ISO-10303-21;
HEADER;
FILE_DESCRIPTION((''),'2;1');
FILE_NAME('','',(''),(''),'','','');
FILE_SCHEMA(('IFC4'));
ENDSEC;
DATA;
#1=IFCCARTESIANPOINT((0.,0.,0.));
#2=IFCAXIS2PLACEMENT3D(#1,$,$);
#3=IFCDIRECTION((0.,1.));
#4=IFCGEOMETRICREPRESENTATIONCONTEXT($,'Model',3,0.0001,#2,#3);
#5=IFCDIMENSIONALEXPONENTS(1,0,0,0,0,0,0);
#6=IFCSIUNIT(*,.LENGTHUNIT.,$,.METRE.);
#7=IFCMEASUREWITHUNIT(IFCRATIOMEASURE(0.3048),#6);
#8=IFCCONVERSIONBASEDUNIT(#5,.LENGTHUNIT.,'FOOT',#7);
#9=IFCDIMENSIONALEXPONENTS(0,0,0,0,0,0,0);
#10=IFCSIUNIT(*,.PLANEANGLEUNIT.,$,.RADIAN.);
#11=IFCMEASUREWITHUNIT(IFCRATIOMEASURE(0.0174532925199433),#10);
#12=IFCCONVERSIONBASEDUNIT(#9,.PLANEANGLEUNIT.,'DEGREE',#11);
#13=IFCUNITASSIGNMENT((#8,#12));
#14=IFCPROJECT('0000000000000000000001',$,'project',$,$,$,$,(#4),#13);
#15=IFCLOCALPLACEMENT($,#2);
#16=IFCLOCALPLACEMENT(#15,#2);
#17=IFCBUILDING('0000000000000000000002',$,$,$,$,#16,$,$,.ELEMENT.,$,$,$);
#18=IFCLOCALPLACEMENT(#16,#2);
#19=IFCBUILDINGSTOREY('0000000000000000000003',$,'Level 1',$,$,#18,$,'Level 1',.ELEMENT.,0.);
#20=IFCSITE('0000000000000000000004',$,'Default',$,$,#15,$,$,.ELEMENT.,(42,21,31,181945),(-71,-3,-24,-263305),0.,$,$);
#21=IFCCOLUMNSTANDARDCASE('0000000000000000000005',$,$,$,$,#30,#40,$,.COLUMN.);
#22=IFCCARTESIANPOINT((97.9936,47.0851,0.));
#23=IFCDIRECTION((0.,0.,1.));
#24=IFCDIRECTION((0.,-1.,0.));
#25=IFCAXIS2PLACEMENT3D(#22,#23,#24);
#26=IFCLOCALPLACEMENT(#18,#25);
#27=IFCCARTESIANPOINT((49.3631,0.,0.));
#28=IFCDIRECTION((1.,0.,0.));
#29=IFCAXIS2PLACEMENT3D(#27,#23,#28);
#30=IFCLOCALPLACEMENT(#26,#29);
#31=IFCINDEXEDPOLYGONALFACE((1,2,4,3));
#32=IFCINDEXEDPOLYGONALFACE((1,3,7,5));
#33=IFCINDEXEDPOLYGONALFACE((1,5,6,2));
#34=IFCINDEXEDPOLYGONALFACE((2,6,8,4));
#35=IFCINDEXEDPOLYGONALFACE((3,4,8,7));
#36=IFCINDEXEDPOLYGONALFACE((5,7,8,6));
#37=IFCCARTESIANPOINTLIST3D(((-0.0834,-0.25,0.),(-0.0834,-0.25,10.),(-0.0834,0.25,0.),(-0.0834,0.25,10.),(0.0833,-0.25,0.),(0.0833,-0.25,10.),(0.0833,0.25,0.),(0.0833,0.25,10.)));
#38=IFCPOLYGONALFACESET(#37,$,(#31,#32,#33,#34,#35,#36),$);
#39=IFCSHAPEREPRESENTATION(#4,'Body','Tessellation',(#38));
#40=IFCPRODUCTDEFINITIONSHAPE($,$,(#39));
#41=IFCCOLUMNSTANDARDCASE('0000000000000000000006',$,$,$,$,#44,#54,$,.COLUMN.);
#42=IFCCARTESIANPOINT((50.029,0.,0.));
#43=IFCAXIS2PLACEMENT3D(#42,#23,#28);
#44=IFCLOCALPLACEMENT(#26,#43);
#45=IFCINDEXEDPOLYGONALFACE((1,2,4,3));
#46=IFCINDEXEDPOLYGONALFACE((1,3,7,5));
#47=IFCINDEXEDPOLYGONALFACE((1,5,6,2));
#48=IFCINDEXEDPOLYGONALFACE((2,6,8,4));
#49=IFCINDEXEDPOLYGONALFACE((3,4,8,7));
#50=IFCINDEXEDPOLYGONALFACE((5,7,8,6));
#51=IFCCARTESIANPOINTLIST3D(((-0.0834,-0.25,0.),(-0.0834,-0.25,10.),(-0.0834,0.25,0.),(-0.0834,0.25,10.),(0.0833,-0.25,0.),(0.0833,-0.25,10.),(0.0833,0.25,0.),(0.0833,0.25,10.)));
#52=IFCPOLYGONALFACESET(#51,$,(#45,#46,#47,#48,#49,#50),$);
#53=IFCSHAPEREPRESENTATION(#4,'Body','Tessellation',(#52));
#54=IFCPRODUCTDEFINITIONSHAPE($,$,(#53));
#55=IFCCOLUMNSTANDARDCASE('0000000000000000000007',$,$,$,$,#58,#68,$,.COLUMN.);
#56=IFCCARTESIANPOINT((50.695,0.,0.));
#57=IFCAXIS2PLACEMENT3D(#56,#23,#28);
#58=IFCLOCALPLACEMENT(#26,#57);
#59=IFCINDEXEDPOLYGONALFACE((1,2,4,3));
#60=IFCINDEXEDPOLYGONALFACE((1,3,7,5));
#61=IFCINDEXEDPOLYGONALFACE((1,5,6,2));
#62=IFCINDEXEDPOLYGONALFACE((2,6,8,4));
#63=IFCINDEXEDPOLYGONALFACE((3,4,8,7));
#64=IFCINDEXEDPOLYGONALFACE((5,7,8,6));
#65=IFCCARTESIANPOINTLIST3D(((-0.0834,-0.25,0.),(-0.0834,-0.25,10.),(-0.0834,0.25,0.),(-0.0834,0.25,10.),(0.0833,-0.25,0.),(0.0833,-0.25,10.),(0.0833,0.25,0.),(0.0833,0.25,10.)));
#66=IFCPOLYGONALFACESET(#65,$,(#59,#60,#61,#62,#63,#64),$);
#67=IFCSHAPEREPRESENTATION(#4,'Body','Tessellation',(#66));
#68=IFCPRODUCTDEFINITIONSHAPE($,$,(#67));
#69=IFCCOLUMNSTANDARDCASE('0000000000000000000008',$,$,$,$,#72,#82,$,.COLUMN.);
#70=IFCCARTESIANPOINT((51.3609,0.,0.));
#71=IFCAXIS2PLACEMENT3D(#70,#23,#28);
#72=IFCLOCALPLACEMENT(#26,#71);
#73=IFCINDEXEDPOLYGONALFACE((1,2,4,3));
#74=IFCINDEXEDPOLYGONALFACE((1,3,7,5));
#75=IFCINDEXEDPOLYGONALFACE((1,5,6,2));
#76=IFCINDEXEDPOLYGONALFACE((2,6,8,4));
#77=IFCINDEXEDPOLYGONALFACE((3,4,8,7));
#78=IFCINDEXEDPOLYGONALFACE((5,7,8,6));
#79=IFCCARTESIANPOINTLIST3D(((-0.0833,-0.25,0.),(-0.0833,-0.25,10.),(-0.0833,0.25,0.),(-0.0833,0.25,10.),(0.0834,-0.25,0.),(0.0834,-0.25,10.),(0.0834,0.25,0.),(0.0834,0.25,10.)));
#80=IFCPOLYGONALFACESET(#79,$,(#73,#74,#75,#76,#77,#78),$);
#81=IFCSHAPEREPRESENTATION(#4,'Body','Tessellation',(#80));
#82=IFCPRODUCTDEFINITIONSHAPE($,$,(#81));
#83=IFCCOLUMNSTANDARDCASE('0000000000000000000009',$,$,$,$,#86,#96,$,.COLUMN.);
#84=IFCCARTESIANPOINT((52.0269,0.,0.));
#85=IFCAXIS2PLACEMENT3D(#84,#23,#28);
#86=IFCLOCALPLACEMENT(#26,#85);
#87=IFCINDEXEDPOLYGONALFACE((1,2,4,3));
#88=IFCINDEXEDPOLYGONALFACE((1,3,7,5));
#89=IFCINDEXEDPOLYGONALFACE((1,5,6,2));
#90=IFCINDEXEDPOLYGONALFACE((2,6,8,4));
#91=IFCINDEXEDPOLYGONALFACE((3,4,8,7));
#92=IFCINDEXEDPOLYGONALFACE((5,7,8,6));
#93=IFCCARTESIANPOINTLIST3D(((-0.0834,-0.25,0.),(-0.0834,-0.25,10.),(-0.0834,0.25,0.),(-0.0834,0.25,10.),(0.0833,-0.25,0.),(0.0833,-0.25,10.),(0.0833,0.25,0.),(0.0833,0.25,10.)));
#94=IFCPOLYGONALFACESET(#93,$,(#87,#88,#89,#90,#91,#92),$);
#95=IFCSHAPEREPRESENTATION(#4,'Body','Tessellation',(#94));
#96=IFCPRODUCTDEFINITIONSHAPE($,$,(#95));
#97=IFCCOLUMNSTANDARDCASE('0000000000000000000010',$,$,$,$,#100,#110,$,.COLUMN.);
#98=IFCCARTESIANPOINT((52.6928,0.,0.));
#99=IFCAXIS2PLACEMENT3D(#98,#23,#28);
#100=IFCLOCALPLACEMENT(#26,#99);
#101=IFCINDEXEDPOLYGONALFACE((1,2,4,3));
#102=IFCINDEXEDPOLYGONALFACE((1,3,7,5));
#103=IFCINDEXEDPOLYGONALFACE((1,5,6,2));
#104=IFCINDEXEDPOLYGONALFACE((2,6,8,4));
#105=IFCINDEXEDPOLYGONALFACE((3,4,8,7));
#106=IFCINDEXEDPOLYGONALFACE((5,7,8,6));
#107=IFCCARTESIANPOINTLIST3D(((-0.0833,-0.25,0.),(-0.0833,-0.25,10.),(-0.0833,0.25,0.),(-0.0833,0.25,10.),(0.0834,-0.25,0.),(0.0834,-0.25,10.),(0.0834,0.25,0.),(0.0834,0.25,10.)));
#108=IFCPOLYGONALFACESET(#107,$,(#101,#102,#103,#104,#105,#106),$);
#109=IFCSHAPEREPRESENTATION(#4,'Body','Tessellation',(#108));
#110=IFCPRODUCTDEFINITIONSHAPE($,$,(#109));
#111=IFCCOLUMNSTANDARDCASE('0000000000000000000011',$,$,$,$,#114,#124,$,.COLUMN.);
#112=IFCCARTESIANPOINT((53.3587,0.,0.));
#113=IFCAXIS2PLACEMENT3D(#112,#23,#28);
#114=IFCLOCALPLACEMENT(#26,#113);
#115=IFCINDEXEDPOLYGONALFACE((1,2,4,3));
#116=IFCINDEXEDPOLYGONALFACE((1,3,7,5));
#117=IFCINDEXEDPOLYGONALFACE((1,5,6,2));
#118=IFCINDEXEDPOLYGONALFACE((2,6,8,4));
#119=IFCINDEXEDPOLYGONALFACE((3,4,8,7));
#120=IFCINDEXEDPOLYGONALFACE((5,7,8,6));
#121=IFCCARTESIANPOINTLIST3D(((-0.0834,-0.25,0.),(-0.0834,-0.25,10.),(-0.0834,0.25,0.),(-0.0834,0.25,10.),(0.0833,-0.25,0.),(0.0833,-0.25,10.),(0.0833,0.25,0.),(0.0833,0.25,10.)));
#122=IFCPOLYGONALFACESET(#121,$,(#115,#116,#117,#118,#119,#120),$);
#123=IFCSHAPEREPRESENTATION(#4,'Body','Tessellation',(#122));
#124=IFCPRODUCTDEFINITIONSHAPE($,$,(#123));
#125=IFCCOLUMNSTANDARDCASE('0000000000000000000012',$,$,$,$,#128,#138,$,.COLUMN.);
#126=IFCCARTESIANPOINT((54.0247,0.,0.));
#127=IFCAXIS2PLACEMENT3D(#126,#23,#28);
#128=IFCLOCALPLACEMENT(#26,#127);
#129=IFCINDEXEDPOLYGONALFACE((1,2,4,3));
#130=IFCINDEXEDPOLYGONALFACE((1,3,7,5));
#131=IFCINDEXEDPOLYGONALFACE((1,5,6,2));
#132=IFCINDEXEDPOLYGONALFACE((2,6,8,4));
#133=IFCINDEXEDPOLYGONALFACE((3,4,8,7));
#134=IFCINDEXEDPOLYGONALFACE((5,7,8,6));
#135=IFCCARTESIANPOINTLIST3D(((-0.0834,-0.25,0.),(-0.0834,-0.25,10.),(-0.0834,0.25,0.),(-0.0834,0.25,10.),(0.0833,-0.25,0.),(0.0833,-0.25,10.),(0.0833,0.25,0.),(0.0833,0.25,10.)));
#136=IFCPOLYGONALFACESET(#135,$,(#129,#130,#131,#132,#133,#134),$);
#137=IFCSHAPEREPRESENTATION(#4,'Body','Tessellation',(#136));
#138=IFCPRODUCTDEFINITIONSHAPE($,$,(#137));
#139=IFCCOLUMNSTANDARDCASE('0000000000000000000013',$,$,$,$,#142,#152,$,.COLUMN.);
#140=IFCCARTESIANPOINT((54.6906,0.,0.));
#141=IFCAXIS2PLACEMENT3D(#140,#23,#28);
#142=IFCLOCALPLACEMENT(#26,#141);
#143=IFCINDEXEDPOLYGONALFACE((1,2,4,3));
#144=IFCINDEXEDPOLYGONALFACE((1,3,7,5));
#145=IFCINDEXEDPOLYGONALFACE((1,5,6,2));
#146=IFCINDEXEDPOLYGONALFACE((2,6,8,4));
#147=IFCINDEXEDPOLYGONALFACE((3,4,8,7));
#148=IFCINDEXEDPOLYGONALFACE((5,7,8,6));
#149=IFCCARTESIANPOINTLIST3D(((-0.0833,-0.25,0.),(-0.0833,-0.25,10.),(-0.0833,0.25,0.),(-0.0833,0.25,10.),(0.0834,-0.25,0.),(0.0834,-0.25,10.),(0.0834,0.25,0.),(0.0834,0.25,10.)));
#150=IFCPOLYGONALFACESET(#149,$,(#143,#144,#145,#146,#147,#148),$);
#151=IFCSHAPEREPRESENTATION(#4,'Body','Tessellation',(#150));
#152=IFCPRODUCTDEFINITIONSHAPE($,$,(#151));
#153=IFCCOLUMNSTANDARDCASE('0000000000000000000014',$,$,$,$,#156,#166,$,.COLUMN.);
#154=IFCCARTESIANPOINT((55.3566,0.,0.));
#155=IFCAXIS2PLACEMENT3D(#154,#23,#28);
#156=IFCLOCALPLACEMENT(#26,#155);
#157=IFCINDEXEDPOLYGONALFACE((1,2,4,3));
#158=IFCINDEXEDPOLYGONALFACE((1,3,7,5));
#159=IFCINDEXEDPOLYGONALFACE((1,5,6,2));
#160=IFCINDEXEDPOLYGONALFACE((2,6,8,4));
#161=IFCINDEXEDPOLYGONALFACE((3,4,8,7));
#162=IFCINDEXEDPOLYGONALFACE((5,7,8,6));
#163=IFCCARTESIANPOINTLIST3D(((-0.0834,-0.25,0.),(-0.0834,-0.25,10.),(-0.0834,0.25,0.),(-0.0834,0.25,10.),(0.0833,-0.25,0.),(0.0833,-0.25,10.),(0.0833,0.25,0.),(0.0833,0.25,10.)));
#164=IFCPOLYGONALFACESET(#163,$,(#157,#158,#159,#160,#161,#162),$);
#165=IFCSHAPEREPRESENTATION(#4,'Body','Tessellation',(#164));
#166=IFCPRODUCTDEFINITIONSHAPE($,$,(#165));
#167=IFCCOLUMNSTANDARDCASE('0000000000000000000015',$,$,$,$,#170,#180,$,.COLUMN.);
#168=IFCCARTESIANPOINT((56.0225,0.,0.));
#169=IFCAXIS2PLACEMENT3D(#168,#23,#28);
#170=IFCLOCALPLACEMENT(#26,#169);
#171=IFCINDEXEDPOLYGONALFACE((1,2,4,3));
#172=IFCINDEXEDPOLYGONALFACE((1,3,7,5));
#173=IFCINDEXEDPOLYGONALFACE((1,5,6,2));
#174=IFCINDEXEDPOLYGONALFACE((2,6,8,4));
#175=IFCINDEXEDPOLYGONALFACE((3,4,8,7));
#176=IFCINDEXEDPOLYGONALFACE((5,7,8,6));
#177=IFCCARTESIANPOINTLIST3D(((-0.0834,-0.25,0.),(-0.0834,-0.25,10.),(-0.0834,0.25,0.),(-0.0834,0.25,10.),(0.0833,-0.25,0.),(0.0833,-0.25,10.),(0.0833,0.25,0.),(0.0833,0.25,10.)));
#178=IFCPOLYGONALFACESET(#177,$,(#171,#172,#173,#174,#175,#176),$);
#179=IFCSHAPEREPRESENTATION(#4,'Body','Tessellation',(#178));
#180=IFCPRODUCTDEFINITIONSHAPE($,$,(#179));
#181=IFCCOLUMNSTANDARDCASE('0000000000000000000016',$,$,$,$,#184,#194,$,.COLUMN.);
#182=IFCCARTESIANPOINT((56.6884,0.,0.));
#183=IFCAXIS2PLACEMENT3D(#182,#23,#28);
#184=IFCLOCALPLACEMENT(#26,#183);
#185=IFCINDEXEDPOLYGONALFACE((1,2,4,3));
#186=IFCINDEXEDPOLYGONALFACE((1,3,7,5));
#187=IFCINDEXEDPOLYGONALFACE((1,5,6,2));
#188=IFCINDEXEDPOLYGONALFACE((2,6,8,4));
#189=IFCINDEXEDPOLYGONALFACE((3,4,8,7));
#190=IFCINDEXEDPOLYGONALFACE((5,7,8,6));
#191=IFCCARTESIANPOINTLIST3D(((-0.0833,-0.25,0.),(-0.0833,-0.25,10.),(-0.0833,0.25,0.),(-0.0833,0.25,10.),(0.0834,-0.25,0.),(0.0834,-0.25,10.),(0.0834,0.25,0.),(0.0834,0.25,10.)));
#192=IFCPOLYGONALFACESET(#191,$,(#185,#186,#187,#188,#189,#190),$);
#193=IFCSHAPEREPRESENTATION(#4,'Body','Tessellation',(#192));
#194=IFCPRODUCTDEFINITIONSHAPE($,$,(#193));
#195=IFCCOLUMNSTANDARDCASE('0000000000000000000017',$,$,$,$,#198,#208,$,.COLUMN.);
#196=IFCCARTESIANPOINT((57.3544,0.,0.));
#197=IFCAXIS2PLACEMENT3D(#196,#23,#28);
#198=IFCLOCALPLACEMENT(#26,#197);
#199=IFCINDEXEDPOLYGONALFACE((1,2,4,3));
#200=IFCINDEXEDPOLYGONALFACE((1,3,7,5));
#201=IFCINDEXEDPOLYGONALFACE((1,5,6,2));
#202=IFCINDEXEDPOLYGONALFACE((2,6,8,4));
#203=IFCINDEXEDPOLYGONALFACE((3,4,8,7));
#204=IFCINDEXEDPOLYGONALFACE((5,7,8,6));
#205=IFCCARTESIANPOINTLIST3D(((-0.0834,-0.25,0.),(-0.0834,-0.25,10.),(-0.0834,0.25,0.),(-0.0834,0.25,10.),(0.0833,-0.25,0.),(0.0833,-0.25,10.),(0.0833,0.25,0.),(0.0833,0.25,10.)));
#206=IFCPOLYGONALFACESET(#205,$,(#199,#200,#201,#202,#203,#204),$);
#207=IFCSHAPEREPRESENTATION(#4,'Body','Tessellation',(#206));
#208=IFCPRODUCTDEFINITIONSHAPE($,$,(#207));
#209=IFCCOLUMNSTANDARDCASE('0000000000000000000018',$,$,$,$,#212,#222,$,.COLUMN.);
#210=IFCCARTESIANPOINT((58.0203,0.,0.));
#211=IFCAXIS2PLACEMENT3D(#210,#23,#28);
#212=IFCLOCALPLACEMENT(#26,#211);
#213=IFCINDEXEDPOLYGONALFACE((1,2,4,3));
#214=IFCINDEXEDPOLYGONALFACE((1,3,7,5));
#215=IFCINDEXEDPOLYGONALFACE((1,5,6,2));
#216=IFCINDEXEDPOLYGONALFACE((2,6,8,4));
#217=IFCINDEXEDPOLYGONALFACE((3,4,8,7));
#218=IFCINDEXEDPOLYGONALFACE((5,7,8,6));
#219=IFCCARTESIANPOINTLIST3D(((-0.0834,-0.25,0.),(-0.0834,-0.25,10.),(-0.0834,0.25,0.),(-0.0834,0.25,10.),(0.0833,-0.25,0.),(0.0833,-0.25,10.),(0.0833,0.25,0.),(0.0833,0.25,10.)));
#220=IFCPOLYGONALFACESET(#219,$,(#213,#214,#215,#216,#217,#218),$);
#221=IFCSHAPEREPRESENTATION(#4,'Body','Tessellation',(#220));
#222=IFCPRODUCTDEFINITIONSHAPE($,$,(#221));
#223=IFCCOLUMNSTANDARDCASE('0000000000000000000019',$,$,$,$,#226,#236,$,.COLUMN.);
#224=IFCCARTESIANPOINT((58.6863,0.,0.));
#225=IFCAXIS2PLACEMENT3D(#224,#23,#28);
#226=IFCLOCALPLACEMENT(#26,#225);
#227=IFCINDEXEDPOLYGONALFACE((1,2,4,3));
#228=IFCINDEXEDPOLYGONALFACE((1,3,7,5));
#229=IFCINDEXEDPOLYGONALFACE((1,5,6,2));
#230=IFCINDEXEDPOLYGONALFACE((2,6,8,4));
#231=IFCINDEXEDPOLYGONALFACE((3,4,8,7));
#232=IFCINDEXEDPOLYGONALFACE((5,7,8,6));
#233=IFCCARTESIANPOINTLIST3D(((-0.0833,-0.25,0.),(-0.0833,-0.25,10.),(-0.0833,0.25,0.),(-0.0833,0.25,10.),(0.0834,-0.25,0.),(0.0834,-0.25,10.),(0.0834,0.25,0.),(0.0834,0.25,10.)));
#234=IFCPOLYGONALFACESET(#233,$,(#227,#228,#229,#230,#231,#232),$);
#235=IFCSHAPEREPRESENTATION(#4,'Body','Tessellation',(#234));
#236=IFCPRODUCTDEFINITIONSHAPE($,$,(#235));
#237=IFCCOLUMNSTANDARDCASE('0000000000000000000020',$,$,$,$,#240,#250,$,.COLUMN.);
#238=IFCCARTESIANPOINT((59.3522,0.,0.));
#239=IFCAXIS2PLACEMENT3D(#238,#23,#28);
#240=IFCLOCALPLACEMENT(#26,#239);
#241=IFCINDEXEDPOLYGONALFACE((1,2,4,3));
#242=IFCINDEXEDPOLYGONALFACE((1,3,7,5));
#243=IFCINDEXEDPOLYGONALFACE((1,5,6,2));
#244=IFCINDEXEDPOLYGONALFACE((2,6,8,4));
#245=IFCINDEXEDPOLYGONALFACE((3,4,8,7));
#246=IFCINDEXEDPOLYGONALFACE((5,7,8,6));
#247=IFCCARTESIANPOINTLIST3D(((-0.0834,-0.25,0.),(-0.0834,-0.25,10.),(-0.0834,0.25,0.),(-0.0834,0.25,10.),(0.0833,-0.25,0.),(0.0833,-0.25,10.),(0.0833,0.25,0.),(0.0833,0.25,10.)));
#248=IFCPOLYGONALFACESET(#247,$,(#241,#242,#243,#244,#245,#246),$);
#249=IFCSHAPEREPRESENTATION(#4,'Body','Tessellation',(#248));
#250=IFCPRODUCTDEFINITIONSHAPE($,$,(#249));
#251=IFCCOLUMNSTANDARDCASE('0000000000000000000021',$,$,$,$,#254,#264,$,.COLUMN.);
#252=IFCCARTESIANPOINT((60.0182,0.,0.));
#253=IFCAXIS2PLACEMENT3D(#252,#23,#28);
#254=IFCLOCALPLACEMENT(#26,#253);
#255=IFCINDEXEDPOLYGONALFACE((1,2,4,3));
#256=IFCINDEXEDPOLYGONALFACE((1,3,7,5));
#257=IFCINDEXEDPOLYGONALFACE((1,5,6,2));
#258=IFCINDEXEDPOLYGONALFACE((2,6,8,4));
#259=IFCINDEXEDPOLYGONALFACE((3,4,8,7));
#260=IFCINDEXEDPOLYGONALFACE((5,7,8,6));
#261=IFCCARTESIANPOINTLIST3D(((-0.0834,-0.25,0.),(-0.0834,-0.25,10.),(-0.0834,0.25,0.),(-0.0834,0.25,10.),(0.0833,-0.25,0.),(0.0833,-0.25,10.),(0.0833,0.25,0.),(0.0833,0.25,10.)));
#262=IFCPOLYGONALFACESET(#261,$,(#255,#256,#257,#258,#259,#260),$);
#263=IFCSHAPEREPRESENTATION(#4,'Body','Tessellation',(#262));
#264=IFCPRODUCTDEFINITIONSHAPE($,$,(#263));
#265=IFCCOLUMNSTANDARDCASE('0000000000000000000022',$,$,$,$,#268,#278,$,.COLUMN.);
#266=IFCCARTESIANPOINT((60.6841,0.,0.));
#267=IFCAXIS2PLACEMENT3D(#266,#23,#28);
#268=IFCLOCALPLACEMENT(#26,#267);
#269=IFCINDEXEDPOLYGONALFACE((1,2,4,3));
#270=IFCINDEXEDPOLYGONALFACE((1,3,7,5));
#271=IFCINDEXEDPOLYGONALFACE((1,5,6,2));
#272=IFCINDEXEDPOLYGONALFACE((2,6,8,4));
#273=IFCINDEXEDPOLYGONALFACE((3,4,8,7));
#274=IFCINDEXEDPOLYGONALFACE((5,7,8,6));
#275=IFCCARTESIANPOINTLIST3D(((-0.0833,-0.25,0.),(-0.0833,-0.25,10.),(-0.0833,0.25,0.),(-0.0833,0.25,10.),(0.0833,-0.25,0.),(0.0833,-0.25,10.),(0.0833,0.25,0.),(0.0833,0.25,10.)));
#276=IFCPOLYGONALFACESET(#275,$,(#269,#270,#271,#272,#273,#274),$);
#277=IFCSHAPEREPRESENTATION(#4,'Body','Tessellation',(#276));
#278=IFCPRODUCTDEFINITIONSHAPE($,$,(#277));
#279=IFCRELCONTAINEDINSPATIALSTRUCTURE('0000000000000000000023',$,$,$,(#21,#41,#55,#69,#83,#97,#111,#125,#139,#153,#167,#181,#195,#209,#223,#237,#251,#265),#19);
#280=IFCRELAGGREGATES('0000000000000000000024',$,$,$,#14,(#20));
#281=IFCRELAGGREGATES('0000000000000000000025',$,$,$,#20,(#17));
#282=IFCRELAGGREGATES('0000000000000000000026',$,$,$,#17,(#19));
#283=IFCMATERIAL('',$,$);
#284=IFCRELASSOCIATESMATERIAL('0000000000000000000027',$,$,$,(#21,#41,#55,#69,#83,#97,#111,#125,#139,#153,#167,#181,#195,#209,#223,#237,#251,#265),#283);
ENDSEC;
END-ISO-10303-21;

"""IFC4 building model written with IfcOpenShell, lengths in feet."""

from ifc_helpers import new_model, entity, si_unit, converted_unit, direction, frame, origin, place, context, project, spatial, rectangle, extrude, material, element, save


model = new_model("IFC4")

# Units and contexts
model_context = context("Model", 3, precision=0.0001, world=origin(), true_north=direction((0.0, 1.0)))
ifc_project = project(units=[converted_unit("LENGTHUNIT", "FOOT", entity("IfcRatioMeasure", 0.3048), si_unit("LENGTHUNIT", "METRE"), dimensions=[1, 0, 0, 0, 0, 0, 0]), converted_unit("PLANEANGLEUNIT", "DEGREE", entity("IfcRatioMeasure", 0.0174532925199433), si_unit("PLANEANGLEUNIT", "RADIAN"), dimensions=[0, 0, 0, 0, 0, 0, 0])], contexts=[model_context])

# Site, building, storey
site_placement = place(None, origin())
site = spatial("IfcSite", under=ifc_project, at=site_placement, Name="Default", CompositionType="ELEMENT", RefLatitude=(42, 21, 31, 181945), RefLongitude=(-71, -3, -24, -263305), RefElevation=0.0)
building_placement = place(site_placement, origin())
building = spatial("IfcBuilding", under=site, at=building_placement, CompositionType="ELEMENT")
storey_placement = place(building_placement, origin())
storey = spatial("IfcBuildingStorey", under=building, at=storey_placement, Name="Level 1", LongName="Level 1", CompositionType="ELEMENT", Elevation=0.0)

# Columns
ifc_material_1 = material(Name="")
placement = place(storey_placement, frame((97.9936, 47.0851, 0.0), z_axis=(0.0, 0.0, 1.0), x_axis=(0.0, -1.0, 0.0)))
for number, where, z_axis, x_axis in (
    (1, (49.3631, 0.0, 0.0), (0.0, 0.0, 1.0), (1.0, 0.0, 0.0)),
    (2, (50.029, 0.0, 0.0), (0.0, 0.0, 1.0), (1.0, 0.0, 0.0)),
    (3, (50.695, 0.0, 0.0), (0.0, 0.0, 1.0), (1.0, 0.0, 0.0)),
    (4, (51.3609, 0.0, 0.0), (0.0, 0.0, 1.0), (1.0, 0.0, 0.0)),
    (5, (52.0269, 0.0, 0.0), (0.0, 0.0, 1.0), (1.0, 0.0, 0.0)),
    (6, (52.6928, 0.0, 0.0), (0.0, 0.0, 1.0), (1.0, 0.0, 0.0)),
    (7, (53.3587, 0.0, 0.0), (0.0, 0.0, 1.0), (1.0, 0.0, 0.0)),
    (8, (54.0247, 0.0, 0.0), (0.0, 0.0, 1.0), (1.0, 0.0, 0.0)),
    (9, (54.6906, 0.0, 0.0), (0.0, 0.0, 1.0), (1.0, 0.0, 0.0)),
    (10, (55.3566, 0.0, 0.0), (0.0, 0.0, 1.0), (1.0, 0.0, 0.0)),
    (11, (56.0225, 0.0, 0.0), (0.0, 0.0, 1.0), (1.0, 0.0, 0.0)),
    (12, (56.6884, 0.0, 0.0), (0.0, 0.0, 1.0), (1.0, 0.0, 0.0)),
    (13, (57.3544, 0.0, 0.0), (0.0, 0.0, 1.0), (1.0, 0.0, 0.0)),
    (14, (58.0203, 0.0, 0.0), (0.0, 0.0, 1.0), (1.0, 0.0, 0.0)),
    (15, (58.6863, 0.0, 0.0), (0.0, 0.0, 1.0), (1.0, 0.0, 0.0)),
    (16, (59.3522, 0.0, 0.0), (0.0, 0.0, 1.0), (1.0, 0.0, 0.0)),
    (17, (60.0182, 0.0, 0.0), (0.0, 0.0, 1.0), (1.0, 0.0, 0.0)),
    (18, (60.6841, 0.0, 0.0), (0.0, 0.0, 1.0), (1.0, 0.0, 0.0)),
):
    element("IfcColumnStandardCase", number, at=place(placement, frame(where, z_axis=z_axis, x_axis=x_axis)), inside=storey, material=ifc_material_1, PredefinedType="COLUMN", context=model_context, shape_type="SweptSolid", body=[
        extrude(rectangle(XDim=0.1667, YDim=0.5), origin(), (0.0, 0.0, 1.0), 10.0),
    ])

save(model, "model.ifc")
